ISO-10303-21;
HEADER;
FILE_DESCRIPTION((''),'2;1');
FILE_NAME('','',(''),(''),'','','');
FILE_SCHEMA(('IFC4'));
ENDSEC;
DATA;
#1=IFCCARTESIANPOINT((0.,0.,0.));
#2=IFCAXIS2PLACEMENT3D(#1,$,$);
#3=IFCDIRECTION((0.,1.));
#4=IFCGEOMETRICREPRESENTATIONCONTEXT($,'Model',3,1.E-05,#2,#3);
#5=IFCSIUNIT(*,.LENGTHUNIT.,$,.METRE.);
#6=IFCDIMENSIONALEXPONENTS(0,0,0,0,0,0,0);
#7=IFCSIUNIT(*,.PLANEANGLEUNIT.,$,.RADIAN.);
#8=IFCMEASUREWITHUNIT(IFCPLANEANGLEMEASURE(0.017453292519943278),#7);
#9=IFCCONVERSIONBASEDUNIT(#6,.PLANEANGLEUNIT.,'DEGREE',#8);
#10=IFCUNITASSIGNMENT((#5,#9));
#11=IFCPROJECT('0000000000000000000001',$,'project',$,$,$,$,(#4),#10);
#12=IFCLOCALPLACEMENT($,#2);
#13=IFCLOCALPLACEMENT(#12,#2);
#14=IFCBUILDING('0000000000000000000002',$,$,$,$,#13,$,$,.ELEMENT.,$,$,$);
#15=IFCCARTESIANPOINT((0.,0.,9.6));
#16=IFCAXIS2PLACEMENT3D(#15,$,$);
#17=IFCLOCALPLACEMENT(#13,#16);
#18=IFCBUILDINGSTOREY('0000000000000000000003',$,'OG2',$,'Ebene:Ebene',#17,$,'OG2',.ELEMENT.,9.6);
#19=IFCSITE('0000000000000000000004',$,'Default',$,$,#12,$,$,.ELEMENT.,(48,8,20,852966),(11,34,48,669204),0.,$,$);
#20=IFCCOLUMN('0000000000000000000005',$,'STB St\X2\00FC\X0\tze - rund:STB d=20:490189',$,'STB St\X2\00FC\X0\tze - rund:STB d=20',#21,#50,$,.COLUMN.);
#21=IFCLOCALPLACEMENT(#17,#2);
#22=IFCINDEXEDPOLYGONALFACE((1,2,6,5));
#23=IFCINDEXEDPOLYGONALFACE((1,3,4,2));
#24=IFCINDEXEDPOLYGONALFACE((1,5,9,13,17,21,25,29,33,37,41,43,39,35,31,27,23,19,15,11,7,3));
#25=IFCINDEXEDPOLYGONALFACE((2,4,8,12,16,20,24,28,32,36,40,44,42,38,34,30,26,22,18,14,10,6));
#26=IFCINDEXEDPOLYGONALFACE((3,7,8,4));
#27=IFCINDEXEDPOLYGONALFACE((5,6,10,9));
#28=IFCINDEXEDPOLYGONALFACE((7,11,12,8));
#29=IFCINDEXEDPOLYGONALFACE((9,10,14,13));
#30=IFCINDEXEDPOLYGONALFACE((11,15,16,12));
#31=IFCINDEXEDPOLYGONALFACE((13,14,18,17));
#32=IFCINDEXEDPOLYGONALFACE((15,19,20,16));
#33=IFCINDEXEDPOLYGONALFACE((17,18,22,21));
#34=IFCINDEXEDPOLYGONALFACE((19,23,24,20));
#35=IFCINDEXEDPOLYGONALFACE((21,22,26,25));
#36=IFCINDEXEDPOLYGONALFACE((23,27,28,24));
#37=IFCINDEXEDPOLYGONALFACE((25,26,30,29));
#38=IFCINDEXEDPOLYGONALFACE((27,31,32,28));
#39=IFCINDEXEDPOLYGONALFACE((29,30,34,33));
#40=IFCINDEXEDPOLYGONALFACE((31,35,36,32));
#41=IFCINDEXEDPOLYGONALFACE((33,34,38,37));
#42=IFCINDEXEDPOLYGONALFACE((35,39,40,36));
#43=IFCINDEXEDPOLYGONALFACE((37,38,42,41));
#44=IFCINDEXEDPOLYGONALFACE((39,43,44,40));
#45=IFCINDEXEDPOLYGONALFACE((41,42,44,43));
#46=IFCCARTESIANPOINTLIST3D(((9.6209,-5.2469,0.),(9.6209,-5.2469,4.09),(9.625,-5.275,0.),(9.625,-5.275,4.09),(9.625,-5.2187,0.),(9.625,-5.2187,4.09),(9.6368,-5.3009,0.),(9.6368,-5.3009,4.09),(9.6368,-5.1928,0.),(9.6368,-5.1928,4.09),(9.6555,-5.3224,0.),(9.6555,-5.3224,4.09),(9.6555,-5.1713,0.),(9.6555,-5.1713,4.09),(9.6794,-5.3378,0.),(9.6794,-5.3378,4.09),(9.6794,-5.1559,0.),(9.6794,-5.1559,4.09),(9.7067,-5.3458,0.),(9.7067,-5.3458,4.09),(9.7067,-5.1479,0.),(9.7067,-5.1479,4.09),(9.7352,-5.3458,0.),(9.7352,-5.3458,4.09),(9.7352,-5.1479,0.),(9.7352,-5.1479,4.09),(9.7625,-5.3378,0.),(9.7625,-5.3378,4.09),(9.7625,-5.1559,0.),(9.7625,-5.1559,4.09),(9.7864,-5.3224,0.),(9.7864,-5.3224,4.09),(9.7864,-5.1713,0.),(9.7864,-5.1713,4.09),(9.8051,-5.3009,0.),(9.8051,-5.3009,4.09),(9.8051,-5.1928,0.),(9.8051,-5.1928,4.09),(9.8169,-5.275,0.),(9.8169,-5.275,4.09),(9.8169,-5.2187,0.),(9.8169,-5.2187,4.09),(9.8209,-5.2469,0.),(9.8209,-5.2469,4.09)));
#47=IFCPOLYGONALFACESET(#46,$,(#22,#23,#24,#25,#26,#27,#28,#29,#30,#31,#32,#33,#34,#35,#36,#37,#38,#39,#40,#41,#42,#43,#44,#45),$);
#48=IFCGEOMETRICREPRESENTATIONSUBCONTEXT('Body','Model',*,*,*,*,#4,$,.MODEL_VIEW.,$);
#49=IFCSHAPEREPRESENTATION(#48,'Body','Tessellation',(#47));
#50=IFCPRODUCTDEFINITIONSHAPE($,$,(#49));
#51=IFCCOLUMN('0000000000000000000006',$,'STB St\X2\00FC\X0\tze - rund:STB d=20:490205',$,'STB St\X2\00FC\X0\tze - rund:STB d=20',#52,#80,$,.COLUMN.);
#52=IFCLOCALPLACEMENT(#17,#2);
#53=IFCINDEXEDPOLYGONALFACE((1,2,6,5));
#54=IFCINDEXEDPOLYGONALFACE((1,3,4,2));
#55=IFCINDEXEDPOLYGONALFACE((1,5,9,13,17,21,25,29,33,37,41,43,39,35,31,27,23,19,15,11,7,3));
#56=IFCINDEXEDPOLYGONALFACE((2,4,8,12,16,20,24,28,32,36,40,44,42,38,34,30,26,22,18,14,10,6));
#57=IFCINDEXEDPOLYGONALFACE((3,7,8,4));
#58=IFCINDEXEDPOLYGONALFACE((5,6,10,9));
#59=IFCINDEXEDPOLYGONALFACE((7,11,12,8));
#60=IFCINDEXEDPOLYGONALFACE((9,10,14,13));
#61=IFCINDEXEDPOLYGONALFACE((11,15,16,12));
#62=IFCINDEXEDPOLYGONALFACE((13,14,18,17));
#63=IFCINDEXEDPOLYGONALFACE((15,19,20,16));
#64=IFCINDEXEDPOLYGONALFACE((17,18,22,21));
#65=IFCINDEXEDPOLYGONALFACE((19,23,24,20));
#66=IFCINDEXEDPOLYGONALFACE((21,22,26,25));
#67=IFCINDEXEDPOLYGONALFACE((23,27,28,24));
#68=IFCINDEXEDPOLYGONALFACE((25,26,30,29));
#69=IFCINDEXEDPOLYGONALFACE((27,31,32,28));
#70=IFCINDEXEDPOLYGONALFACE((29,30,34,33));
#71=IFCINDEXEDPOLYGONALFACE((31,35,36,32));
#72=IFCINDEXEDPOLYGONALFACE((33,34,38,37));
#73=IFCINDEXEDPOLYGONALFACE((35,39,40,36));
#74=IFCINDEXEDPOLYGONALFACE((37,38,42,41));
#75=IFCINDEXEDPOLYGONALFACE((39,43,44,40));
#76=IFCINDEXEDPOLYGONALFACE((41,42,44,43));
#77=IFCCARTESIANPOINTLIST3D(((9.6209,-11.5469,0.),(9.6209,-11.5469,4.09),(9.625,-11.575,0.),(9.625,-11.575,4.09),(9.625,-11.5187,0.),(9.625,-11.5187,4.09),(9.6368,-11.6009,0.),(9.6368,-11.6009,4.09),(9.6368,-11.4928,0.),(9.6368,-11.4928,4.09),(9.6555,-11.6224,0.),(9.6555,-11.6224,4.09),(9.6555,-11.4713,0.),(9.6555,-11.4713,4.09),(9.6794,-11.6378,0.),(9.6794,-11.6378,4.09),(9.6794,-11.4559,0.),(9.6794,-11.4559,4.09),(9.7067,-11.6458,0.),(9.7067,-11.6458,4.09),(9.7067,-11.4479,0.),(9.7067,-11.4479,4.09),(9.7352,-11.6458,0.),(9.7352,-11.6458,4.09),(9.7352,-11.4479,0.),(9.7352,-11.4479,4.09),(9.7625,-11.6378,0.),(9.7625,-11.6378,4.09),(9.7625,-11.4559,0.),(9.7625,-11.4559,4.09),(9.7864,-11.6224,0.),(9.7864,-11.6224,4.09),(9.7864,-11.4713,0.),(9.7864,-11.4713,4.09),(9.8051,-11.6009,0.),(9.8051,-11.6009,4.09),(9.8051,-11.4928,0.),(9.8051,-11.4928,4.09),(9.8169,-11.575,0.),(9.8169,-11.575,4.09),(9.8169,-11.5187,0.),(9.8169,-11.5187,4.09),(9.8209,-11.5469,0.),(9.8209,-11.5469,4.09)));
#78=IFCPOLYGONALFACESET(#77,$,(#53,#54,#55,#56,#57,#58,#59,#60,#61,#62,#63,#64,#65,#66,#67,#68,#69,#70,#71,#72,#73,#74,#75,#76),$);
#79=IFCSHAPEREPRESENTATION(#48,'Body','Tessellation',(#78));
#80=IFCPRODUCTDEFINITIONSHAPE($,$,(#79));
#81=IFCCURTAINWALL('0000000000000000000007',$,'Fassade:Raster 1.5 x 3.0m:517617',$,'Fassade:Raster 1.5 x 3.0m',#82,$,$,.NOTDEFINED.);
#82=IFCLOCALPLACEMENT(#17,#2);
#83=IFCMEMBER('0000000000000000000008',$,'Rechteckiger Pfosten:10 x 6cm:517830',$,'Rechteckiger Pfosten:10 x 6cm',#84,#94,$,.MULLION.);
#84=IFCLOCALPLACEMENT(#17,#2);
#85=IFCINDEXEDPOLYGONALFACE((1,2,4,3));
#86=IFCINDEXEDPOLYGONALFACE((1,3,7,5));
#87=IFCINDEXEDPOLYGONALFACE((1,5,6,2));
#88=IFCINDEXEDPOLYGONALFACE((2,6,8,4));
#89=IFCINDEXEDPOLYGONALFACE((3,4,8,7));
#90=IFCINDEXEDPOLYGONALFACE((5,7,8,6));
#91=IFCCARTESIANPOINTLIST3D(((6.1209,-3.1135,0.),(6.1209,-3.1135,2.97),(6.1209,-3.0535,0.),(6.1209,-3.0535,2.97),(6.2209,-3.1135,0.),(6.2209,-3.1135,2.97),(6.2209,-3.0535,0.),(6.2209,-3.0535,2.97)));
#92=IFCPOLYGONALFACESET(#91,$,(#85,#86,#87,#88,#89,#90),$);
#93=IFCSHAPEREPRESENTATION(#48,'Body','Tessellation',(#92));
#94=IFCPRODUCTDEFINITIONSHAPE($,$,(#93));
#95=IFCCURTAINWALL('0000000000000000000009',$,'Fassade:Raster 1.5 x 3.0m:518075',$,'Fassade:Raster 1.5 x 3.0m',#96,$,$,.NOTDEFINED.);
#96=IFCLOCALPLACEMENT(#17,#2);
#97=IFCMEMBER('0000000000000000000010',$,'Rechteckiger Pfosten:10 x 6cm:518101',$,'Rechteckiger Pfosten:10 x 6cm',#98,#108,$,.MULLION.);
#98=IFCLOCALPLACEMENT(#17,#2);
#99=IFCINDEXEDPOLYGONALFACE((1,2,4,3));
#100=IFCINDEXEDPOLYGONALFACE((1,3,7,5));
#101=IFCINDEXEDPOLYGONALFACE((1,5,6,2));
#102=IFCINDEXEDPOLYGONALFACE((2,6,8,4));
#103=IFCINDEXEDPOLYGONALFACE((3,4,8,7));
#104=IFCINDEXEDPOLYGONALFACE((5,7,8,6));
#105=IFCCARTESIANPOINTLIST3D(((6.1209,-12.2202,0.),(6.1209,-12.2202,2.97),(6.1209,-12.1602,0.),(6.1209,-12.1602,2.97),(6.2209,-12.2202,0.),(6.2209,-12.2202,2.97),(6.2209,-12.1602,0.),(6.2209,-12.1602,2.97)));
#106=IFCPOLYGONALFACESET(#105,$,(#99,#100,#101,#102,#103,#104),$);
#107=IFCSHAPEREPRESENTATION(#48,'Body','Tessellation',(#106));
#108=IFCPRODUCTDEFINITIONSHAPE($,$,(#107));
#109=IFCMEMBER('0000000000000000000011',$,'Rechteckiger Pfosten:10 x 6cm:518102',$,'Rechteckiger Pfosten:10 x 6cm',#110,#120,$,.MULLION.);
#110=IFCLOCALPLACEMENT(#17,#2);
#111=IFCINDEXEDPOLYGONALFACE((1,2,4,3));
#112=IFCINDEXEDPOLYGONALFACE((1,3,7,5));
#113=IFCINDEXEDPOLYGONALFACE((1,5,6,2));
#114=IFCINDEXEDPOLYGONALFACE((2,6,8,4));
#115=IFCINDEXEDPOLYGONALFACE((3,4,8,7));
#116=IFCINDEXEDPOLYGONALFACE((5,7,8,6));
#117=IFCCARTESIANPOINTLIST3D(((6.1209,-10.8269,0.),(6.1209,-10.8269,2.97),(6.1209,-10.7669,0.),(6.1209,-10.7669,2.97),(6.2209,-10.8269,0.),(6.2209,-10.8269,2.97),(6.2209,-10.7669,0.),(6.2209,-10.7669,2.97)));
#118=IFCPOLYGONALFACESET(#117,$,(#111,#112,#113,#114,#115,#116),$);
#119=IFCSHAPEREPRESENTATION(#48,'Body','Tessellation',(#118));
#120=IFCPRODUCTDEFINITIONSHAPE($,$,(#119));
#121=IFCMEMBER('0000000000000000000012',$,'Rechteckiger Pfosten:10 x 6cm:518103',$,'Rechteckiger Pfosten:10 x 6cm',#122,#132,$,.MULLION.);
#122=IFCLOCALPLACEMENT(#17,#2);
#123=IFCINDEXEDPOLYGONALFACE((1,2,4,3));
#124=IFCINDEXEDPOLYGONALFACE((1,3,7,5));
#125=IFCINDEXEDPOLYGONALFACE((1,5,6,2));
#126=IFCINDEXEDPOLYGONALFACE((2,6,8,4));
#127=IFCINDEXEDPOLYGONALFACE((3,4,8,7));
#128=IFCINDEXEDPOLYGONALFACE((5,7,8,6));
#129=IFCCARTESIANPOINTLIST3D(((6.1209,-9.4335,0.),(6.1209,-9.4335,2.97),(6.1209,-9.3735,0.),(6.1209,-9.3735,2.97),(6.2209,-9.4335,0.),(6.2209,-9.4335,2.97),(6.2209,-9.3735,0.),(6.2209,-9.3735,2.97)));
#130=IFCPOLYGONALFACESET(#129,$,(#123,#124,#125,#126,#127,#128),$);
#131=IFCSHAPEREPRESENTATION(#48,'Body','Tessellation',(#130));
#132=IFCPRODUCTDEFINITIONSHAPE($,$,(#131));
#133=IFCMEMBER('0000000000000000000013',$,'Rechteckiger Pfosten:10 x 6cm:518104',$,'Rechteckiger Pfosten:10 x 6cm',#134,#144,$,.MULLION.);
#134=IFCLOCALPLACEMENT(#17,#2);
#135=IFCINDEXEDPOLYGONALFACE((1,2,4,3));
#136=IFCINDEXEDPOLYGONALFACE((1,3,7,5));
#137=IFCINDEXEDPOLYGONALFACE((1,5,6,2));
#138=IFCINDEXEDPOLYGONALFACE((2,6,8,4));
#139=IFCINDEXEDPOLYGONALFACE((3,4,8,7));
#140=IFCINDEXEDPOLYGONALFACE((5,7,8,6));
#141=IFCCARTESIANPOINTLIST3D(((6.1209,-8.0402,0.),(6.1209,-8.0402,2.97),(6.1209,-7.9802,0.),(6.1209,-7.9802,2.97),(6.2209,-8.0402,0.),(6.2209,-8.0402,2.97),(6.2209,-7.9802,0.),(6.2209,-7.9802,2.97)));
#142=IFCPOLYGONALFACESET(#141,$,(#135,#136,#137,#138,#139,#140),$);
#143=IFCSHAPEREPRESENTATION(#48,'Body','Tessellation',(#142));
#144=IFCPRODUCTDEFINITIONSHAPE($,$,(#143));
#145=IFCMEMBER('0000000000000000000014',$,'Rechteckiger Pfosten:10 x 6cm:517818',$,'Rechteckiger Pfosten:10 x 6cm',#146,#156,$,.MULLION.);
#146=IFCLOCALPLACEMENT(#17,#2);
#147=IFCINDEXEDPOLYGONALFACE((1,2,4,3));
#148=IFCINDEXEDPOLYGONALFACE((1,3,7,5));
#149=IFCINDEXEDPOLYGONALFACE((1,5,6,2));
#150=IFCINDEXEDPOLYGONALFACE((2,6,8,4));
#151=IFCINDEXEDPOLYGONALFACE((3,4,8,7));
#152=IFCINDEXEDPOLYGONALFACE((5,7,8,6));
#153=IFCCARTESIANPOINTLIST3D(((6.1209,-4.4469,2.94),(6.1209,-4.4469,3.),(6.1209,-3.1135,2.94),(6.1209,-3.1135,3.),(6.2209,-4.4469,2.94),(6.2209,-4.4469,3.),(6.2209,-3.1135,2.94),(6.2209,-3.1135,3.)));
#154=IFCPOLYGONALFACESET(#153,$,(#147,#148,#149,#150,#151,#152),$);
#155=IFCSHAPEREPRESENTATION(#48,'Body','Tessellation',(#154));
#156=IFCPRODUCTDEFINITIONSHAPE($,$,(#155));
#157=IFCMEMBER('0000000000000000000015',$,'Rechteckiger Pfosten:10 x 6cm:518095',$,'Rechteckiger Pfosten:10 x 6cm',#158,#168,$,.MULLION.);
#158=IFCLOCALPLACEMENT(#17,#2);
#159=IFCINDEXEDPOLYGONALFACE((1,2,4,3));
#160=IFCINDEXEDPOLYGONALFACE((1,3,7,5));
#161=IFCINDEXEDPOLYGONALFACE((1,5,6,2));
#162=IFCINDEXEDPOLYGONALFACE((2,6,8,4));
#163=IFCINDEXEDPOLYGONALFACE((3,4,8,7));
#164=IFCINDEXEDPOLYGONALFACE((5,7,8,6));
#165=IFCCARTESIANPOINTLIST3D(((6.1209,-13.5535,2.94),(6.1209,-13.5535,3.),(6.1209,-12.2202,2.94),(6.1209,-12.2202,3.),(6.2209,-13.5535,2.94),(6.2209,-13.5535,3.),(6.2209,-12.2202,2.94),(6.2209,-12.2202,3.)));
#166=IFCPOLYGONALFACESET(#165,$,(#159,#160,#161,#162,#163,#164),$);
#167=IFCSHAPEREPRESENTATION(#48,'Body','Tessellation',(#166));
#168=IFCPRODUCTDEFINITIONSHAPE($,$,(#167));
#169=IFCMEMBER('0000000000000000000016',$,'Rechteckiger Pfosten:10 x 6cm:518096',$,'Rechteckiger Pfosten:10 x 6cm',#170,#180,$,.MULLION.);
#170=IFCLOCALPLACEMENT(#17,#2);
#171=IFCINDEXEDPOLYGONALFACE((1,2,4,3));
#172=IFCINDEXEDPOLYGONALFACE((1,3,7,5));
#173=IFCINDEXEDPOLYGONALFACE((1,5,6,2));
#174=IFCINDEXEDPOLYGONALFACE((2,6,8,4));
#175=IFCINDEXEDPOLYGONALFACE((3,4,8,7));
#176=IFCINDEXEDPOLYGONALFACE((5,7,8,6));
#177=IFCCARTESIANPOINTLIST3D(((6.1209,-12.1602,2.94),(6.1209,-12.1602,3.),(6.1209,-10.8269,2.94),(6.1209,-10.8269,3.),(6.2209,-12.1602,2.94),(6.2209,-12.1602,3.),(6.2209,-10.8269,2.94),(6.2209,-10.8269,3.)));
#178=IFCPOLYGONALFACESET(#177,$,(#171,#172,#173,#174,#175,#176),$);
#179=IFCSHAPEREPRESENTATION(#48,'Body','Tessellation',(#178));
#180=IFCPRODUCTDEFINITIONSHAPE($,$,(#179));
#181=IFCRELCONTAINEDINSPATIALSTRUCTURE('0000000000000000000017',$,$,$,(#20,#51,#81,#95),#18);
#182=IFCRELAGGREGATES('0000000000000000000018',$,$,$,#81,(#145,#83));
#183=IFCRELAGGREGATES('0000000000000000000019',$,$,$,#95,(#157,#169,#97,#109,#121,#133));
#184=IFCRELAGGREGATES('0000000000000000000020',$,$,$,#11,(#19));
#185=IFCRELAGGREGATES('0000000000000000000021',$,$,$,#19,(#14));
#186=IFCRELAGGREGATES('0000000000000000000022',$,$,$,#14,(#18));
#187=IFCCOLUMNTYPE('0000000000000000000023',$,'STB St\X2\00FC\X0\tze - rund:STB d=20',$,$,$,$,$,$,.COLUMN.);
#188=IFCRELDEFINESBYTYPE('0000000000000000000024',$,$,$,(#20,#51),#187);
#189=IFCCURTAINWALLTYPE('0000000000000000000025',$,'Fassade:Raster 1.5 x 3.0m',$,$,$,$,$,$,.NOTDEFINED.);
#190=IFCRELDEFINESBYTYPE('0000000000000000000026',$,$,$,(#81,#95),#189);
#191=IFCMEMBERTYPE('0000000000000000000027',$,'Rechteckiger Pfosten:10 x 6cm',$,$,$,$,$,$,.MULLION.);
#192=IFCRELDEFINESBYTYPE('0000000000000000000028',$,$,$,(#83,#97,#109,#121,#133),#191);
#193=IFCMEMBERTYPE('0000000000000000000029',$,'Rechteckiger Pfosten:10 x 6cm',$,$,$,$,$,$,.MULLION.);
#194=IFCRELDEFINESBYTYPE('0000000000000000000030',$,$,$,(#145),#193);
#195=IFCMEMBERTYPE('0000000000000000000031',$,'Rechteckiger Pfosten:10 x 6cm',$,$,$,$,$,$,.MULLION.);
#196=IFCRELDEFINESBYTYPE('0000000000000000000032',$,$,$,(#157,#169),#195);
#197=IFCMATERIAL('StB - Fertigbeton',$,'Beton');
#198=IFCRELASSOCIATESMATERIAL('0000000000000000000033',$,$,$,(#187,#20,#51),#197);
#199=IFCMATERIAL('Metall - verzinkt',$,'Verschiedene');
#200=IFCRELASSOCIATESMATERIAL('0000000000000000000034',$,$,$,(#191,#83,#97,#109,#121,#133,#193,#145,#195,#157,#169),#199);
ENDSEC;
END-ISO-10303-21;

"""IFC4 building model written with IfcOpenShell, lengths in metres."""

from ifc_helpers import new_model, entity, si_unit, converted_unit, direction, frame, origin, place, context, subcontext, project, spatial, arc, indexed_curve, outline, extrude, source, transform, mapped, material, type_object, type_shapes, element, aggregate, save


model = new_model("IFC4")

# Units and contexts
model_context = context("Model", 3, precision=1e-05, world=origin(), true_north=direction((0.0, 1.0)))
body_context = subcontext(model_context, "Body", "Model", "MODEL_VIEW")
ifc_project = project(units=[si_unit("LENGTHUNIT", "METRE"), converted_unit("PLANEANGLEUNIT", "DEGREE", entity("IfcPlaneAngleMeasure", 0.017453292519943278), si_unit("PLANEANGLEUNIT", "RADIAN"), dimensions=[0, 0, 0, 0, 0, 0, 0])], contexts=[model_context])

# Site, building, storey
site_placement = place(None, origin())
site = spatial("IfcSite", under=ifc_project, at=site_placement, Name="Default", CompositionType="ELEMENT", RefLatitude=(48, 8, 20, 852966), RefLongitude=(11, 34, 48, 669204), RefElevation=0.0)
building_placement = place(site_placement, origin())
building = spatial("IfcBuilding", under=site, at=building_placement, CompositionType="ELEMENT")
storey_placement = place(building_placement, frame((0.0, 0.0, 9.6)))
storey = spatial("IfcBuildingStorey", under=building, at=storey_placement, Name="OG2", ObjectType="Ebene:Ebene", LongName="OG2", CompositionType="ELEMENT", Elevation=9.6)

# Columns
ifc_material_1 = material(Name="StB - Fertigbeton", Category="Beton")
column_type = type_object("IfcColumnType", Name="STB Stütze - rund:STB d=20", PredefinedType="COLUMN", material=ifc_material_1)
shared_shape_1 = source(origin(), body_context, "Body", "SweptSolid", [
    extrude(outline(indexed_curve([(-0.1, 0.0), (0.0, -0.1), (0.1, 0.0), (0.0, 0.1)], segments=[arc(1, 2, 3), arc(3, 4, 1)], self_intersect=False)), frame((0.0, 0.0, 9.6)), (0.0, 0.0, 1.0), 4.09),
])
type_shapes(column_type, [shared_shape_1])
for number, where, name in (
    (1, (9.7209, -5.2469, -9.6), "STB Stütze - rund:STB d=20:490189"),
    (2, (9.7209, -11.5469, -9.6), "STB Stütze - rund:STB d=20:490205"),
):
    element("IfcColumn", number, at=place(storey_placement, frame(where)), inside=storey, type_object=column_type, material=ifc_material_1, Name=name, ObjectType="STB Stütze - rund:STB d=20", PredefinedType="COLUMN", context=body_context, shape_type="MappedRepresentation", body=[
        mapped(shared_shape_1, transform((0.0, 0.0, 0.0), scale=1.0)),
    ])

# Curtain wall, member
curtain_wall_type = type_object("IfcCurtainWallType", Name="Fassade:Raster 1.5 x 3.0m", PredefinedType="NOTDEFINED")
curtain_wall_1_placement = place(storey_placement, frame((0.0, 0.0, -9.6)))
curtain_wall_1 = element("IfcCurtainWall", 3, at=curtain_wall_1_placement, inside=storey, type_object=curtain_wall_type, Name="Fassade:Raster 1.5 x 3.0m:517617", ObjectType="Fassade:Raster 1.5 x 3.0m", PredefinedType="NOTDEFINED")
ifc_material_2 = material(Name="Metall - verzinkt", Category="Verschiedene")
member_type_1 = type_object("IfcMemberType", Name="Rechteckiger Pfosten:10 x 6cm", PredefinedType="MULLION", material=ifc_material_2)
shared_shape_2 = source(origin(), body_context, "Body", "SweptSolid", [
    extrude(outline(indexed_curve([(-0.03, -0.05), (0.03, -0.05), (0.03, 0.05), (-0.03, 0.05), (-0.03, -0.05)], self_intersect=False)), frame((0.0, 0.0, -2.97), z_axis=(0.0, 0.0, 1.0), x_axis=(-1.0, 0.0, 0.0)), (0.0, 0.0, 1.0), 2.97),
])
type_shapes(member_type_1, [shared_shape_2])
member_1_placement = place(curtain_wall_1_placement, frame((6.1709, -3.0835, 9.6), z_axis=(0.0, 0.0, -1.0), x_axis=(0.0, 1.0, 0.0)))
member_1 = element("IfcMember", 4, at=member_1_placement, type_object=member_type_1, material=ifc_material_2, Name="Rechteckiger Pfosten:10 x 6cm:517830", ObjectType="Rechteckiger Pfosten:10 x 6cm", PredefinedType="MULLION", context=body_context, shape_type="MappedRepresentation", body=[
    mapped(shared_shape_2, transform((0.0, 0.0, 0.0), scale=1.0)),
])

# Curtain wall, members
curtain_wall_2_placement = place(storey_placement, frame((0.0, 0.0, -9.6)))
curtain_wall_2 = element("IfcCurtainWall", 5, at=curtain_wall_2_placement, inside=storey, type_object=curtain_wall_type, Name="Fassade:Raster 1.5 x 3.0m:518075", ObjectType="Fassade:Raster 1.5 x 3.0m", PredefinedType="NOTDEFINED")
member_2_placement = place(curtain_wall_2_placement, frame((6.1709, -12.1902, 9.6), z_axis=(0.0, 0.0, -1.0), x_axis=(0.0, 1.0, 0.0)))
member_2 = element("IfcMember", 6, at=member_2_placement, type_object=member_type_1, material=ifc_material_2, Name="Rechteckiger Pfosten:10 x 6cm:518101", ObjectType="Rechteckiger Pfosten:10 x 6cm", PredefinedType="MULLION", context=body_context, shape_type="MappedRepresentation", body=[
    mapped(shared_shape_2, transform((0.0, 0.0, 0.0), scale=1.0)),
])
member_3_placement = place(curtain_wall_2_placement, frame((6.1709, -10.7969, 9.6), z_axis=(0.0, 0.0, -1.0), x_axis=(0.0, 1.0, 0.0)))
member_3 = element("IfcMember", 7, at=member_3_placement, type_object=member_type_1, material=ifc_material_2, Name="Rechteckiger Pfosten:10 x 6cm:518102", ObjectType="Rechteckiger Pfosten:10 x 6cm", PredefinedType="MULLION", context=body_context, shape_type="MappedRepresentation", body=[
    mapped(shared_shape_2, transform((0.0, 0.0, 0.0), scale=1.0)),
])
member_4_placement = place(curtain_wall_2_placement, frame((6.1709, -9.4035, 9.6), z_axis=(0.0, 0.0, -1.0), x_axis=(0.0, 1.0, 0.0)))
member_4 = element("IfcMember", 8, at=member_4_placement, type_object=member_type_1, material=ifc_material_2, Name="Rechteckiger Pfosten:10 x 6cm:518103", ObjectType="Rechteckiger Pfosten:10 x 6cm", PredefinedType="MULLION", context=body_context, shape_type="MappedRepresentation", body=[
    mapped(shared_shape_2, transform((0.0, 0.0, 0.0), scale=1.0)),
])
member_5_placement = place(curtain_wall_2_placement, frame((6.1709, -8.0102, 9.6), z_axis=(0.0, 0.0, -1.0), x_axis=(0.0, 1.0, 0.0)))
member_5 = element("IfcMember", 9, at=member_5_placement, type_object=member_type_1, material=ifc_material_2, Name="Rechteckiger Pfosten:10 x 6cm:518104", ObjectType="Rechteckiger Pfosten:10 x 6cm", PredefinedType="MULLION", context=body_context, shape_type="MappedRepresentation", body=[
    mapped(shared_shape_2, transform((0.0, 0.0, 0.0), scale=1.0)),
])

# Members
member_type_2 = type_object("IfcMemberType", Name="Rechteckiger Pfosten:10 x 6cm", PredefinedType="MULLION", material=ifc_material_2)
shared_shape_3 = source(origin(), body_context, "Body", "SweptSolid", [
    extrude(outline(indexed_curve([(-0.03, -0.05), (0.03, -0.05), (0.03, 0.05), (-0.03, 0.05), (-0.03, -0.05)], self_intersect=False)), frame((0.0, 0.0, -1.3333), z_axis=(0.0, 0.0, 1.0), x_axis=(-1.0, 0.0, 0.0)), (0.0, 0.0, 1.0), 1.3333),
])
type_shapes(member_type_2, [shared_shape_3])
member_6_placement = place(curtain_wall_1_placement, frame((6.1709, -3.1135, 12.57), z_axis=(0.0, 1.0, 0.0), x_axis=(0.0, 0.0, 1.0)))
member_6 = element("IfcMember", 10, at=member_6_placement, type_object=member_type_2, material=ifc_material_2, Name="Rechteckiger Pfosten:10 x 6cm:517818", ObjectType="Rechteckiger Pfosten:10 x 6cm", PredefinedType="MULLION", context=body_context, shape_type="MappedRepresentation", body=[
    mapped(shared_shape_3, transform((0.0, 0.0, 0.0), scale=1.0)),
])
member_type_3 = type_object("IfcMemberType", Name="Rechteckiger Pfosten:10 x 6cm", PredefinedType="MULLION", material=ifc_material_2)
shared_shape_4 = source(origin(), body_context, "Body", "SweptSolid", [
    extrude(outline(indexed_curve([(-0.03, -0.05), (0.03, -0.05), (0.03, 0.05), (-0.03, 0.05), (-0.03, -0.05)], self_intersect=False)), frame((0.0, 0.0, -1.3333), z_axis=(0.0, 0.0, 1.0), x_axis=(-1.0, 0.0, 0.0)), (0.0, 0.0, 1.0), 1.3333),
])
type_shapes(member_type_3, [shared_shape_4])
member_7_placement = place(curtain_wall_2_placement, frame((6.1709, -12.2202, 12.57), z_axis=(0.0, 1.0, 0.0), x_axis=(0.0, 0.0, 1.0)))
member_7 = element("IfcMember", 11, at=member_7_placement, type_object=member_type_3, material=ifc_material_2, Name="Rechteckiger Pfosten:10 x 6cm:518095", ObjectType="Rechteckiger Pfosten:10 x 6cm", PredefinedType="MULLION", context=body_context, shape_type="MappedRepresentation", body=[
    mapped(shared_shape_4, transform((0.0, 0.0, 0.0), scale=1.0)),
])
member_8_placement = place(curtain_wall_2_placement, frame((6.1709, -10.8269, 12.57), z_axis=(0.0, 1.0, 0.0), x_axis=(0.0, 0.0, 1.0)))
member_8 = element("IfcMember", 12, at=member_8_placement, type_object=member_type_3, material=ifc_material_2, Name="Rechteckiger Pfosten:10 x 6cm:518096", ObjectType="Rechteckiger Pfosten:10 x 6cm", PredefinedType="MULLION", context=body_context, shape_type="MappedRepresentation", body=[
    mapped(shared_shape_4, transform((0.0, 0.0, 0.0), scale=1.0)),
])

aggregate(curtain_wall_1, [member_6, member_1])
aggregate(curtain_wall_2, [member_7, member_8, member_2, member_3, member_4, member_5])

save(model, "model.ifc")
